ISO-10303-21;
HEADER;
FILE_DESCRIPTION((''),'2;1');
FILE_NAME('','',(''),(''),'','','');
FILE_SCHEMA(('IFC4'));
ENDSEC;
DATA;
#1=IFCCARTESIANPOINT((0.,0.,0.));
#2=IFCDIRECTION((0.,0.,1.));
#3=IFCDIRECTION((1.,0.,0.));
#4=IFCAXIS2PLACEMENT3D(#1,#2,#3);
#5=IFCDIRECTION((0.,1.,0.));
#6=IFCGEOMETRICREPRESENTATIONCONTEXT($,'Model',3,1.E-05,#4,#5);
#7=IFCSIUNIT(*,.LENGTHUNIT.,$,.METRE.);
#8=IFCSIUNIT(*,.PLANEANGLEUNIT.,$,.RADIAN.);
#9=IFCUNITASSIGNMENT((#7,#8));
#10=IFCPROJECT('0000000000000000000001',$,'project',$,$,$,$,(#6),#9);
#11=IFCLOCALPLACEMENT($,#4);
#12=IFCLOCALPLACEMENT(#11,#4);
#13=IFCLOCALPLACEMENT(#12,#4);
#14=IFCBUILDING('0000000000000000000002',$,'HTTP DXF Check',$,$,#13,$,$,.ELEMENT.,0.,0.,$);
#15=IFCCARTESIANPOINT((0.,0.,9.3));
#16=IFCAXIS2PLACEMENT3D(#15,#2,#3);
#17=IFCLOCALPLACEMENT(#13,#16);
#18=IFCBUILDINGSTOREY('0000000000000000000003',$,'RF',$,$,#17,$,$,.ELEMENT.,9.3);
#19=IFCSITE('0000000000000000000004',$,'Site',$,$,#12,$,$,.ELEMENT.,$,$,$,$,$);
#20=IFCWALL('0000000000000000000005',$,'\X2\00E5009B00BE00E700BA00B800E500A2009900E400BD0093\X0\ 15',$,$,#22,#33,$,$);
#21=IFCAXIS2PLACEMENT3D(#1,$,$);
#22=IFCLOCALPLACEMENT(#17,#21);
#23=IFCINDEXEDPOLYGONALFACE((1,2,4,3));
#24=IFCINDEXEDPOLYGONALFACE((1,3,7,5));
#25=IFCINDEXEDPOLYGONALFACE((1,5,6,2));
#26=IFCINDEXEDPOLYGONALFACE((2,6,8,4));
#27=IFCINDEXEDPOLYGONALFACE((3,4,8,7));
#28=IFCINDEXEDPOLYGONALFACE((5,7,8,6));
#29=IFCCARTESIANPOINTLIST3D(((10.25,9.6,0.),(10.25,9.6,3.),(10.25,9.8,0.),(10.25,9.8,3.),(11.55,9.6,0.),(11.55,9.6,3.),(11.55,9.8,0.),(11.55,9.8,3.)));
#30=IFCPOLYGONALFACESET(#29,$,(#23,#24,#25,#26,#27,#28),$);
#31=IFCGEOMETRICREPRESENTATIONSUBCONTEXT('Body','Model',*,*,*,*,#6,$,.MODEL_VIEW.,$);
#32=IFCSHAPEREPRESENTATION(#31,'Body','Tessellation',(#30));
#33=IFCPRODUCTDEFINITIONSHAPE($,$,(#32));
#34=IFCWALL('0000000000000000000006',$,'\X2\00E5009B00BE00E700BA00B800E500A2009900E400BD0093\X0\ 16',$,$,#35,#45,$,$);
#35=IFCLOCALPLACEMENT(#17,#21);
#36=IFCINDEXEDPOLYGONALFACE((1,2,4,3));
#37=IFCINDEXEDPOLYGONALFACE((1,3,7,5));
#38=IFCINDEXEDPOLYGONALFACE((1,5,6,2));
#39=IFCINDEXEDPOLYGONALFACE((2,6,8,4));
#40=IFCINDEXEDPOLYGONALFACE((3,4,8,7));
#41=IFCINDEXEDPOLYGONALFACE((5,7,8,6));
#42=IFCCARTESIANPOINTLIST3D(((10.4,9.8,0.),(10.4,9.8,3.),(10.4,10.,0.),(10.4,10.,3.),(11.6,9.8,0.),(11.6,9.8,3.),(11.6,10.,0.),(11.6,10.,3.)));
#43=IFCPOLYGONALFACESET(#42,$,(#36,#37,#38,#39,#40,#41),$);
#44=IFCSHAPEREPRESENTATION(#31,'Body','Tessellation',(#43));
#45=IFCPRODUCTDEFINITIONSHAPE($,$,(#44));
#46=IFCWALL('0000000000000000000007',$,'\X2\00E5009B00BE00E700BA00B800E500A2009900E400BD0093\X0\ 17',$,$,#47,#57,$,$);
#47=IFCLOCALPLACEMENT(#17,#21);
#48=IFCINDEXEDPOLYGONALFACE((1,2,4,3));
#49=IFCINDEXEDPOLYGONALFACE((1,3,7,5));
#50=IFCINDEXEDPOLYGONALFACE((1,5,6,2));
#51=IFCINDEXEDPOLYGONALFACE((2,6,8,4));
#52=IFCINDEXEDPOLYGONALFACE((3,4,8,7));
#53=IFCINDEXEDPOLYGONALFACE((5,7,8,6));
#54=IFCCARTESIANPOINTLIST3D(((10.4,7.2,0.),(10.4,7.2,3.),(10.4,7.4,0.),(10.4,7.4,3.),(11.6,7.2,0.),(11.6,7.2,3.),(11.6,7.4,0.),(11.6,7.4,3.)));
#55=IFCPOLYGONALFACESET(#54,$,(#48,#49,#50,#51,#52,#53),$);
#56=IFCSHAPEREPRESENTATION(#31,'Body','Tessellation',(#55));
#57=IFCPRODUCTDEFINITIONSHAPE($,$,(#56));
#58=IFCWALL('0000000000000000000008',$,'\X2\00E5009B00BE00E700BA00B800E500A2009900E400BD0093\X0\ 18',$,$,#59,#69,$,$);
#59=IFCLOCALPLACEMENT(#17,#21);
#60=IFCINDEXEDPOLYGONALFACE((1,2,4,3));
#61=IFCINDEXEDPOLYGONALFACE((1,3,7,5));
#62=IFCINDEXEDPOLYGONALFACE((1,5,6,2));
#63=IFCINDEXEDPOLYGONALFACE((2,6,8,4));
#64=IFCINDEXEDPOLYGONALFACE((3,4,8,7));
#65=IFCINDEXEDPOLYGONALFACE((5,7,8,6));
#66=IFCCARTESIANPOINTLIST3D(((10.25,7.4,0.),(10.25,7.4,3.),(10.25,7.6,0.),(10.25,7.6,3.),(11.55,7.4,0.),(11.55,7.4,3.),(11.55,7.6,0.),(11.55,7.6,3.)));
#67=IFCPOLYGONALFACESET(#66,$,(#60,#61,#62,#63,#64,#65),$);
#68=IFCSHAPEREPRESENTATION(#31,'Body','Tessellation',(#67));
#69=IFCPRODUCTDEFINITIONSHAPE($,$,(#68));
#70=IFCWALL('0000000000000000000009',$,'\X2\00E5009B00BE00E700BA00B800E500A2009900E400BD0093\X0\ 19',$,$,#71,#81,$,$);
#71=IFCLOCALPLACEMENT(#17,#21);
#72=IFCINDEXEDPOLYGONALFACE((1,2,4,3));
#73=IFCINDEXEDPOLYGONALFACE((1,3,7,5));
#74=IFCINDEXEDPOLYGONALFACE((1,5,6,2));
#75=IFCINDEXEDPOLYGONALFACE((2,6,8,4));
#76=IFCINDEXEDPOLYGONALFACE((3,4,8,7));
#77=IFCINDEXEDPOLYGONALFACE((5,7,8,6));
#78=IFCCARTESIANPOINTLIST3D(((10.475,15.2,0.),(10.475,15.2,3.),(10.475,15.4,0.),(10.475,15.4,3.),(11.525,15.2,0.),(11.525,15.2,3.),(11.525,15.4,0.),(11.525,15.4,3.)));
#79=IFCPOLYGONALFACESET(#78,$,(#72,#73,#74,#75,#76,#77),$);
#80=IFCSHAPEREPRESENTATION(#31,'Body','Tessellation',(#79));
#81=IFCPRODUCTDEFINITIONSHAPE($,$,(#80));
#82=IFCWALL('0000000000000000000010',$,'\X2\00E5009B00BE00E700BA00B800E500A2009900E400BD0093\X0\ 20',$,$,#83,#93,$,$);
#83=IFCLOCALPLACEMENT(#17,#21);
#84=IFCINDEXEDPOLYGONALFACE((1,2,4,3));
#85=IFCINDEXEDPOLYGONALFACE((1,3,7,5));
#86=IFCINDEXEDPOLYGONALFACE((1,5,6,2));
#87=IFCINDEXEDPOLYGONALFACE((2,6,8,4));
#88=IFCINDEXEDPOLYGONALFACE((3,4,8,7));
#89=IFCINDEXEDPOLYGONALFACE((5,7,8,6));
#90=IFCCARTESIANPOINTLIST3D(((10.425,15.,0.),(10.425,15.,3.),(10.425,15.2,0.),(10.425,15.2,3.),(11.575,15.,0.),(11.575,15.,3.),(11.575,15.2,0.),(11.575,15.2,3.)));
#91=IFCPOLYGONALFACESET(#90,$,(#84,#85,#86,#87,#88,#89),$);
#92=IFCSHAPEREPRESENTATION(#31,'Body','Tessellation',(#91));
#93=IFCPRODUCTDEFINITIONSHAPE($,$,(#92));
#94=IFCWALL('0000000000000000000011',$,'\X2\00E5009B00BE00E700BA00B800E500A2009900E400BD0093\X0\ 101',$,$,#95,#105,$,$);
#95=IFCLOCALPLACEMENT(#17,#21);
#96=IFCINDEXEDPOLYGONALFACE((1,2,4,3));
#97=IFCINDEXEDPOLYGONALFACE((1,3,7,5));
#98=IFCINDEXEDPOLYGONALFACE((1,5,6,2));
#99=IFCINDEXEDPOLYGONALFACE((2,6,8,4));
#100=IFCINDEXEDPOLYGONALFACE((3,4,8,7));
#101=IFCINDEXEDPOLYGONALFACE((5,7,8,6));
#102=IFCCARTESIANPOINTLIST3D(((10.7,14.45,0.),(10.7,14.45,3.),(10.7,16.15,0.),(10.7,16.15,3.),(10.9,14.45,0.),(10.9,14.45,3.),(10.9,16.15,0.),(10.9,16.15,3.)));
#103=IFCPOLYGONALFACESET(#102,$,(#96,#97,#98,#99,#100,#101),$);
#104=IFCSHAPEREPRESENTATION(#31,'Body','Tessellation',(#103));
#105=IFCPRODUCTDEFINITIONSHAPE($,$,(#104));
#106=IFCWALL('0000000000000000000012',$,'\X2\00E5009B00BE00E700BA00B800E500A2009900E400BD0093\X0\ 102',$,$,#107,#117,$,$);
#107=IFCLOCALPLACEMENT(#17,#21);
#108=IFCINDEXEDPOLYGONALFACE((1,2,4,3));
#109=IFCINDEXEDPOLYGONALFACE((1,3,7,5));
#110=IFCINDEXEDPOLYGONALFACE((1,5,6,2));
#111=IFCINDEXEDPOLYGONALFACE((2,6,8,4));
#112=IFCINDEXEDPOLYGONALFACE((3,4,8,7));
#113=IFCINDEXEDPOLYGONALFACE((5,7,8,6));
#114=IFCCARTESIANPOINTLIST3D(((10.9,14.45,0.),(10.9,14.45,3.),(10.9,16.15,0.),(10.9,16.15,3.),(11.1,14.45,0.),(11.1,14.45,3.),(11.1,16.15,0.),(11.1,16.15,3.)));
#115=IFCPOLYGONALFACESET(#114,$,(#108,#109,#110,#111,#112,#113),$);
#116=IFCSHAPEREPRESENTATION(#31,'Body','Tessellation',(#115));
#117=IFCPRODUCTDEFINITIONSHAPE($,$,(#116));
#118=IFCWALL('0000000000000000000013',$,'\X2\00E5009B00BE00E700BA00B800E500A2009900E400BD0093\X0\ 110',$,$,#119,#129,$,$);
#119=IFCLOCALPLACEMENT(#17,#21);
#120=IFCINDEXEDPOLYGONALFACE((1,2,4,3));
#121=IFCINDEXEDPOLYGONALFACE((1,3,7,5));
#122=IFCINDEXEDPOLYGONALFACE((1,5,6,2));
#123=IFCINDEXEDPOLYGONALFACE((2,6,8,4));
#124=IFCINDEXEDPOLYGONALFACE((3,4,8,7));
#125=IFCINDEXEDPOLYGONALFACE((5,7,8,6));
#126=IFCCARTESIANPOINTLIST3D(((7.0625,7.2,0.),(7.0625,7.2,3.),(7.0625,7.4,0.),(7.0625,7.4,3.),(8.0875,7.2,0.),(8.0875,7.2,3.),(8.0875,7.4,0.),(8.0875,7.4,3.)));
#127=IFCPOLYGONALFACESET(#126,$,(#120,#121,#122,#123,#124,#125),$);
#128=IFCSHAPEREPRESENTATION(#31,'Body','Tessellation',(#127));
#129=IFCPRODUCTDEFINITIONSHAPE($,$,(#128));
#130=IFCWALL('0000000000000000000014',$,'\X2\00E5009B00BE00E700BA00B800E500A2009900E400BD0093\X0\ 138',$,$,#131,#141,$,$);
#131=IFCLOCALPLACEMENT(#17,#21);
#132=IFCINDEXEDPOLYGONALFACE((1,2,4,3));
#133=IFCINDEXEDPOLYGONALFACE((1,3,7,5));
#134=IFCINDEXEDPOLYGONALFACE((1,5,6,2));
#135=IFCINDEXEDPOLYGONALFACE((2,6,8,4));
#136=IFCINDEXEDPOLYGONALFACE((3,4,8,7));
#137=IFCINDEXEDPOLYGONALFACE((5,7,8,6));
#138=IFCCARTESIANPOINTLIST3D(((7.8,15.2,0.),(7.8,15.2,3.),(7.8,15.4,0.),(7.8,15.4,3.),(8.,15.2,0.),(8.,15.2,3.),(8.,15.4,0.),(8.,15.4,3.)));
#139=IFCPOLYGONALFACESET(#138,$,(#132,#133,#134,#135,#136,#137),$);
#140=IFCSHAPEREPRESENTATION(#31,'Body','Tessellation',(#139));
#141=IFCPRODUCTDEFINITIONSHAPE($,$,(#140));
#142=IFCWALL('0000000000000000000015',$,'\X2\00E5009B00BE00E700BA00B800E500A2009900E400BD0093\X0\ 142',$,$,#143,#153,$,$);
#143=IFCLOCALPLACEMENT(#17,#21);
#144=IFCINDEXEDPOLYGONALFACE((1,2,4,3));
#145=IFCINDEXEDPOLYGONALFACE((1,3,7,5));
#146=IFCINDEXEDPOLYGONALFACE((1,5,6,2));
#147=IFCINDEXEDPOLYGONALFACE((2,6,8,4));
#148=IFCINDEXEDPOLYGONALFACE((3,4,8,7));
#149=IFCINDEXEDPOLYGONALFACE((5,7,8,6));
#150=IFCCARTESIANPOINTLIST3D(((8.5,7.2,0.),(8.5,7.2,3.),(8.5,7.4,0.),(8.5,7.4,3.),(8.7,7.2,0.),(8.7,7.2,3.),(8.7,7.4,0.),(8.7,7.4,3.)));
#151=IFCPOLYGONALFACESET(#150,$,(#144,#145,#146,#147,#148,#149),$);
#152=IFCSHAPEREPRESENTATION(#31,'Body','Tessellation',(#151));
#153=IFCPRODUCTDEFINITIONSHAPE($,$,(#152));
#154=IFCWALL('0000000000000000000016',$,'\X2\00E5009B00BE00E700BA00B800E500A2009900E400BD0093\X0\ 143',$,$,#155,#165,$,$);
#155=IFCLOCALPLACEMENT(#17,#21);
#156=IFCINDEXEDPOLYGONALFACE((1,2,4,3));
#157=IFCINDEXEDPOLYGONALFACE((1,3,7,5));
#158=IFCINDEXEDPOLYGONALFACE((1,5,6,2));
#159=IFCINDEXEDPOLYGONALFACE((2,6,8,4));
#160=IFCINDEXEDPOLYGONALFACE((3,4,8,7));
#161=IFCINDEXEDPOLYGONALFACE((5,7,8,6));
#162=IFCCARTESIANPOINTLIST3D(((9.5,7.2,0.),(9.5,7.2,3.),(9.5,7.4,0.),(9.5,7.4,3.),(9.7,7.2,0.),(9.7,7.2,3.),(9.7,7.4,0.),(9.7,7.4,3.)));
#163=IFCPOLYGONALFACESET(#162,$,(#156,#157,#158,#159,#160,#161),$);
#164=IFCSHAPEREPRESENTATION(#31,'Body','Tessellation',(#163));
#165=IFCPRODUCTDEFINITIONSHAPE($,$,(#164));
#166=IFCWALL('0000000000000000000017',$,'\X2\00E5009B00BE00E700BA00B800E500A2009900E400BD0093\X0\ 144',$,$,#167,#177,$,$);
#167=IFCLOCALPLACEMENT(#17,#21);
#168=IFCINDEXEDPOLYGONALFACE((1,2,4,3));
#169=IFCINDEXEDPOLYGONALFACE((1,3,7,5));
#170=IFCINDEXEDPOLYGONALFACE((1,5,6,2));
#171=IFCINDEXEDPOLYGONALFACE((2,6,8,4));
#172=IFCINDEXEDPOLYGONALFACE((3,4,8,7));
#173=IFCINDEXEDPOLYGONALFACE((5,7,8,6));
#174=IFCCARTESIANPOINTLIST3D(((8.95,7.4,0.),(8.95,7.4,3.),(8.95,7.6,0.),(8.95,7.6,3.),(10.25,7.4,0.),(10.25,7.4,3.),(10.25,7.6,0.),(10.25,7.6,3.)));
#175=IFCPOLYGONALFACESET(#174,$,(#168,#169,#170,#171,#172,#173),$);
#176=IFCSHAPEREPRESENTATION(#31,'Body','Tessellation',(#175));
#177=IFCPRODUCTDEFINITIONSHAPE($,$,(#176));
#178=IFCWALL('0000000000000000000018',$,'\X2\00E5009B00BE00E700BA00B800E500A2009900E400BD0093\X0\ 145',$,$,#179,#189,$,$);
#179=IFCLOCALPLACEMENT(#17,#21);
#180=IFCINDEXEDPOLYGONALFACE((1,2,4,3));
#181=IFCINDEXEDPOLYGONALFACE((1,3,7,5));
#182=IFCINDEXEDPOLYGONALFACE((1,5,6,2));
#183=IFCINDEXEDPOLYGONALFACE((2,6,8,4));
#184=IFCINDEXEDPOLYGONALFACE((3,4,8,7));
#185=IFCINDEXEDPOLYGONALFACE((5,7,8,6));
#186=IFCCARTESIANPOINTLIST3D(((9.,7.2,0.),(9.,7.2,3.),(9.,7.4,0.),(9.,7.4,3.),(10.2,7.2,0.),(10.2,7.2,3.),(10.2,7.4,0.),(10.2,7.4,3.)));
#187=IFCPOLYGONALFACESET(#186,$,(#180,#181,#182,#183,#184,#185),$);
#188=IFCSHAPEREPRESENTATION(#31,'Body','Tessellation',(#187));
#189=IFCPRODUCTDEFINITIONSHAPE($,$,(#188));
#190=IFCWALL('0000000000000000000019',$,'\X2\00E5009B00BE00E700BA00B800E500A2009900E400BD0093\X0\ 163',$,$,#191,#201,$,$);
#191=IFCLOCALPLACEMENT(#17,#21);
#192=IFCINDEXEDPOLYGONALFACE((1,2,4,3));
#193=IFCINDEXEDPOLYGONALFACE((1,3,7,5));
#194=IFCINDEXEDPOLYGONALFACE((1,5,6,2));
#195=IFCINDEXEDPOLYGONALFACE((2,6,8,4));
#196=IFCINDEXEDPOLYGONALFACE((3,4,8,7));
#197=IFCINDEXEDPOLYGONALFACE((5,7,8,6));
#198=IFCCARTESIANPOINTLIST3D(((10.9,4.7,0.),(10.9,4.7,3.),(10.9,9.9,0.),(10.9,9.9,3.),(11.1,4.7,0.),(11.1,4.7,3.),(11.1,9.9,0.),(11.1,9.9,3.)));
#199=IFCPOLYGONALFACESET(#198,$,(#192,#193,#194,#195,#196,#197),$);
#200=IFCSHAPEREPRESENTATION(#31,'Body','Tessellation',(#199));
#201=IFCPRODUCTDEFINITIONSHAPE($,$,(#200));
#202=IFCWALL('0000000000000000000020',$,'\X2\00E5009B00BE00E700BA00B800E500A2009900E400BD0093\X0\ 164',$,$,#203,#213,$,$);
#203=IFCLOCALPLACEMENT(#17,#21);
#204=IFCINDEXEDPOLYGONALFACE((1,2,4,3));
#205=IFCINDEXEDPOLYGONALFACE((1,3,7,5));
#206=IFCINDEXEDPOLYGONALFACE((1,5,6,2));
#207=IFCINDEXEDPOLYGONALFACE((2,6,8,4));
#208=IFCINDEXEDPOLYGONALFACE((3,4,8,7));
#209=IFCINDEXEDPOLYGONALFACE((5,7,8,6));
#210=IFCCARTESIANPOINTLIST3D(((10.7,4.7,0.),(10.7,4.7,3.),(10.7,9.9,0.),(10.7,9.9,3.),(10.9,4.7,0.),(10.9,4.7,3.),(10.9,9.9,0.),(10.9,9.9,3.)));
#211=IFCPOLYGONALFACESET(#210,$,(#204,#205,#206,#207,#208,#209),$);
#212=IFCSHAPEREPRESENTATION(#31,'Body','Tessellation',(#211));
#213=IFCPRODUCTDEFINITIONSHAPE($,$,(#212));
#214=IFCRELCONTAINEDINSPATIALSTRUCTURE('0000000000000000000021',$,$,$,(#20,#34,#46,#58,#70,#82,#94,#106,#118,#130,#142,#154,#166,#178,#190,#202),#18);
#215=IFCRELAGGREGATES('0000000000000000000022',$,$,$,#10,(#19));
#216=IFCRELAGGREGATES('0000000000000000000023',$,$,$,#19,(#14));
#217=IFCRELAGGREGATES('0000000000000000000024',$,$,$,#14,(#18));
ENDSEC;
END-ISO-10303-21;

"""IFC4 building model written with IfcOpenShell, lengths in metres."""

from ifc_helpers import new_model, si_unit, direction, frame, frame_2d, origin_with_axes, place, context, subcontext, project, spatial, rectangle, extrude, element, save


model = new_model("IFC4")

# Units and contexts
model_context = context("Model", 3, precision=1e-05, world=origin_with_axes(), true_north=direction((0.0, 1.0, 0.0)))
body_context = subcontext(model_context, "Body", "Model", "MODEL_VIEW")
ifc_project = project(units=[si_unit("LENGTHUNIT", "METRE"), si_unit("PLANEANGLEUNIT", "RADIAN")], contexts=[model_context])

# Site, building, storey
placement = place(None, origin_with_axes())
site_placement = place(placement, origin_with_axes())
site = spatial("IfcSite", under=ifc_project, at=site_placement, Name="Site", CompositionType="ELEMENT")
building_placement = place(site_placement, origin_with_axes())
building = spatial("IfcBuilding", under=site, at=building_placement, Name="HTTP DXF Check", CompositionType="ELEMENT", ElevationOfRefHeight=0.0, ElevationOfTerrain=0.0)
storey_placement = place(building_placement, frame((0.0, 0.0, 9.3), z_axis=(0.0, 0.0, 1.0), x_axis=(1.0, 0.0, 0.0)))
storey = spatial("IfcBuildingStorey", under=building, at=storey_placement, Name="RF", CompositionType="ELEMENT", Elevation=9.3)

# Walls
wall_1_placement = place(storey_placement, frame((10.9, 9.7, 0.0), z_axis=(0.0, 0.0, 1.0), x_axis=(1.0, 0.0, 0.0)))
element("IfcWall", 1, at=wall_1_placement, inside=storey, Name="å\u009b¾çº¸å¢\u0099ä½\u0093 15", context=body_context, shape_type="SweptSolid", body=[
    extrude(rectangle(XDim=1.3, YDim=0.2, at=frame_2d((0.0, 0.0), x_axis=(1.0, 0.0, 0.0))), frame((0.0, 0.0, 0.0), z_axis=(0.0, 0.0, 1.0)), (0.0, 0.0, 1.0), 3.0),
])
for number, where, z_axis, x_axis, name in (
    (2, (11.0, 9.9, 0.0), (0.0, 0.0, 1.0), (1.0, 0.0, 0.0), "å\u009b¾çº¸å¢\u0099ä½\u0093 16"),
    (3, (11.0, 7.3, 0.0), (0.0, 0.0, 1.0), (1.0, 0.0, 0.0), "å\u009b¾çº¸å¢\u0099ä½\u0093 17"),
):
    element("IfcWall", number, at=place(storey_placement, frame(where, z_axis=z_axis, x_axis=x_axis)), inside=storey, Name=name, context=body_context, shape_type="SweptSolid", body=[
        extrude(rectangle(XDim=1.2, YDim=0.2, at=frame_2d((0.0, 0.0), x_axis=(1.0, 0.0, 0.0))), frame((0.0, 0.0, 0.0), z_axis=(0.0, 0.0, 1.0)), (0.0, 0.0, 1.0), 3.0),
    ])
wall_2_placement = place(storey_placement, frame((10.9, 7.5, 0.0), z_axis=(0.0, 0.0, 1.0), x_axis=(1.0, 0.0, 0.0)))
element("IfcWall", 4, at=wall_2_placement, inside=storey, Name="å\u009b¾çº¸å¢\u0099ä½\u0093 18", context=body_context, shape_type="SweptSolid", body=[
    extrude(rectangle(XDim=1.3, YDim=0.2, at=frame_2d((0.0, 0.0), x_axis=(1.0, 0.0, 0.0))), frame((0.0, 0.0, 0.0), z_axis=(0.0, 0.0, 1.0)), (0.0, 0.0, 1.0), 3.0),
])
wall_3_placement = place(storey_placement, frame((11.0, 15.3, 0.0), z_axis=(0.0, 0.0, 1.0), x_axis=(1.0, 0.0, 0.0)))
element("IfcWall", 5, at=wall_3_placement, inside=storey, Name="å\u009b¾çº¸å¢\u0099ä½\u0093 19", context=body_context, shape_type="SweptSolid", body=[
    extrude(rectangle(XDim=1.05, YDim=0.2, at=frame_2d((0.0, 0.0), x_axis=(1.0, 0.0, 0.0))), frame((0.0, 0.0, 0.0), z_axis=(0.0, 0.0, 1.0)), (0.0, 0.0, 1.0), 3.0),
])
wall_4_placement = place(storey_placement, frame((11.0, 15.1, 0.0), z_axis=(0.0, 0.0, 1.0), x_axis=(1.0, 0.0, 0.0)))
element("IfcWall", 6, at=wall_4_placement, inside=storey, Name="å\u009b¾çº¸å¢\u0099ä½\u0093 20", context=body_context, shape_type="SweptSolid", body=[
    extrude(rectangle(XDim=1.15, YDim=0.2, at=frame_2d((0.0, 0.0), x_axis=(1.0, 0.0, 0.0))), frame((0.0, 0.0, 0.0), z_axis=(0.0, 0.0, 1.0)), (0.0, 0.0, 1.0), 3.0),
])
for number, where, z_axis, x_axis, name in (
    (7, (10.8, 15.3, 0.0), (0.0, 0.0, 1.0), (0.0, 1.0, 0.0), "å\u009b¾çº¸å¢\u0099ä½\u0093 101"),
    (8, (11.0, 15.3, 0.0), (0.0, 0.0, 1.0), (0.0, 1.0, 0.0), "å\u009b¾çº¸å¢\u0099ä½\u0093 102"),
):
    element("IfcWall", number, at=place(storey_placement, frame(where, z_axis=z_axis, x_axis=x_axis)), inside=storey, Name=name, context=body_context, shape_type="SweptSolid", body=[
        extrude(rectangle(XDim=1.7, YDim=0.2, at=frame_2d((0.0, 0.0), x_axis=(1.0, 0.0, 0.0))), frame((0.0, 0.0, 0.0), z_axis=(0.0, 0.0, 1.0)), (0.0, 0.0, 1.0), 3.0),
    ])
wall_5_placement = place(storey_placement, frame((7.575, 7.3, 0.0), z_axis=(0.0, 0.0, 1.0), x_axis=(1.0, 0.0, 0.0)))
element("IfcWall", 9, at=wall_5_placement, inside=storey, Name="å\u009b¾çº¸å¢\u0099ä½\u0093 110", context=body_context, shape_type="SweptSolid", body=[
    extrude(rectangle(XDim=1.025, YDim=0.2, at=frame_2d((0.0, 0.0), x_axis=(1.0, 0.0, 0.0))), frame((0.0, 0.0, 0.0), z_axis=(0.0, 0.0, 1.0)), (0.0, 0.0, 1.0), 3.0),
])
for number, where, z_axis, x_axis, name in (
    (10, (7.9, 15.3, 0.0), (0.0, 0.0, 1.0), (0.0, -1.0, 0.0), "å\u009b¾çº¸å¢\u0099ä½\u0093 138"),
    (11, (8.6, 7.3, 0.0), (0.0, 0.0, 1.0), (0.0, 1.0, 0.0), "å\u009b¾çº¸å¢\u0099ä½\u0093 142"),
    (12, (9.6, 7.3, 0.0), (0.0, 0.0, 1.0), (0.0, 1.0, 0.0), "å\u009b¾çº¸å¢\u0099ä½\u0093 143"),
):
    element("IfcWall", number, at=place(storey_placement, frame(where, z_axis=z_axis, x_axis=x_axis)), inside=storey, Name=name, context=body_context, shape_type="SweptSolid", body=[
        extrude(rectangle(XDim=0.2, YDim=0.2, at=frame_2d((0.0, 0.0), x_axis=(1.0, 0.0, 0.0))), frame((0.0, 0.0, 0.0), z_axis=(0.0, 0.0, 1.0)), (0.0, 0.0, 1.0), 3.0),
    ])
wall_6_placement = place(storey_placement, frame((9.6, 7.5, 0.0), z_axis=(0.0, 0.0, 1.0), x_axis=(1.0, 0.0, 0.0)))
element("IfcWall", 13, at=wall_6_placement, inside=storey, Name="å\u009b¾çº¸å¢\u0099ä½\u0093 144", context=body_context, shape_type="SweptSolid", body=[
    extrude(rectangle(XDim=1.3, YDim=0.2, at=frame_2d((0.0, 0.0), x_axis=(1.0, 0.0, 0.0))), frame((0.0, 0.0, 0.0), z_axis=(0.0, 0.0, 1.0)), (0.0, 0.0, 1.0), 3.0),
])
wall_7_placement = place(storey_placement, frame((9.6, 7.3, 0.0), z_axis=(0.0, 0.0, 1.0), x_axis=(1.0, 0.0, 0.0)))
element("IfcWall", 14, at=wall_7_placement, inside=storey, Name="å\u009b¾çº¸å¢\u0099ä½\u0093 145", context=body_context, shape_type="SweptSolid", body=[
    extrude(rectangle(XDim=1.2, YDim=0.2, at=frame_2d((0.0, 0.0), x_axis=(1.0, 0.0, 0.0))), frame((0.0, 0.0, 0.0), z_axis=(0.0, 0.0, 1.0)), (0.0, 0.0, 1.0), 3.0),
])
for number, where, z_axis, x_axis, name in (
    (15, (11.0, 7.3, 0.0), (0.0, 0.0, 1.0), (0.0, -1.0, 0.0), "å\u009b¾çº¸å¢\u0099ä½\u0093 163"),
    (16, (10.8, 7.3, 0.0), (0.0, 0.0, 1.0), (0.0, -1.0, 0.0), "å\u009b¾çº¸å¢\u0099ä½\u0093 164"),
):
    element("IfcWall", number, at=place(storey_placement, frame(where, z_axis=z_axis, x_axis=x_axis)), inside=storey, Name=name, context=body_context, shape_type="SweptSolid", body=[
        extrude(rectangle(XDim=5.2, YDim=0.2, at=frame_2d((0.0, 0.0), x_axis=(1.0, 0.0, 0.0))), frame((0.0, 0.0, 0.0), z_axis=(0.0, 0.0, 1.0)), (0.0, 0.0, 1.0), 3.0),
    ])

save(model, "model.ifc")
